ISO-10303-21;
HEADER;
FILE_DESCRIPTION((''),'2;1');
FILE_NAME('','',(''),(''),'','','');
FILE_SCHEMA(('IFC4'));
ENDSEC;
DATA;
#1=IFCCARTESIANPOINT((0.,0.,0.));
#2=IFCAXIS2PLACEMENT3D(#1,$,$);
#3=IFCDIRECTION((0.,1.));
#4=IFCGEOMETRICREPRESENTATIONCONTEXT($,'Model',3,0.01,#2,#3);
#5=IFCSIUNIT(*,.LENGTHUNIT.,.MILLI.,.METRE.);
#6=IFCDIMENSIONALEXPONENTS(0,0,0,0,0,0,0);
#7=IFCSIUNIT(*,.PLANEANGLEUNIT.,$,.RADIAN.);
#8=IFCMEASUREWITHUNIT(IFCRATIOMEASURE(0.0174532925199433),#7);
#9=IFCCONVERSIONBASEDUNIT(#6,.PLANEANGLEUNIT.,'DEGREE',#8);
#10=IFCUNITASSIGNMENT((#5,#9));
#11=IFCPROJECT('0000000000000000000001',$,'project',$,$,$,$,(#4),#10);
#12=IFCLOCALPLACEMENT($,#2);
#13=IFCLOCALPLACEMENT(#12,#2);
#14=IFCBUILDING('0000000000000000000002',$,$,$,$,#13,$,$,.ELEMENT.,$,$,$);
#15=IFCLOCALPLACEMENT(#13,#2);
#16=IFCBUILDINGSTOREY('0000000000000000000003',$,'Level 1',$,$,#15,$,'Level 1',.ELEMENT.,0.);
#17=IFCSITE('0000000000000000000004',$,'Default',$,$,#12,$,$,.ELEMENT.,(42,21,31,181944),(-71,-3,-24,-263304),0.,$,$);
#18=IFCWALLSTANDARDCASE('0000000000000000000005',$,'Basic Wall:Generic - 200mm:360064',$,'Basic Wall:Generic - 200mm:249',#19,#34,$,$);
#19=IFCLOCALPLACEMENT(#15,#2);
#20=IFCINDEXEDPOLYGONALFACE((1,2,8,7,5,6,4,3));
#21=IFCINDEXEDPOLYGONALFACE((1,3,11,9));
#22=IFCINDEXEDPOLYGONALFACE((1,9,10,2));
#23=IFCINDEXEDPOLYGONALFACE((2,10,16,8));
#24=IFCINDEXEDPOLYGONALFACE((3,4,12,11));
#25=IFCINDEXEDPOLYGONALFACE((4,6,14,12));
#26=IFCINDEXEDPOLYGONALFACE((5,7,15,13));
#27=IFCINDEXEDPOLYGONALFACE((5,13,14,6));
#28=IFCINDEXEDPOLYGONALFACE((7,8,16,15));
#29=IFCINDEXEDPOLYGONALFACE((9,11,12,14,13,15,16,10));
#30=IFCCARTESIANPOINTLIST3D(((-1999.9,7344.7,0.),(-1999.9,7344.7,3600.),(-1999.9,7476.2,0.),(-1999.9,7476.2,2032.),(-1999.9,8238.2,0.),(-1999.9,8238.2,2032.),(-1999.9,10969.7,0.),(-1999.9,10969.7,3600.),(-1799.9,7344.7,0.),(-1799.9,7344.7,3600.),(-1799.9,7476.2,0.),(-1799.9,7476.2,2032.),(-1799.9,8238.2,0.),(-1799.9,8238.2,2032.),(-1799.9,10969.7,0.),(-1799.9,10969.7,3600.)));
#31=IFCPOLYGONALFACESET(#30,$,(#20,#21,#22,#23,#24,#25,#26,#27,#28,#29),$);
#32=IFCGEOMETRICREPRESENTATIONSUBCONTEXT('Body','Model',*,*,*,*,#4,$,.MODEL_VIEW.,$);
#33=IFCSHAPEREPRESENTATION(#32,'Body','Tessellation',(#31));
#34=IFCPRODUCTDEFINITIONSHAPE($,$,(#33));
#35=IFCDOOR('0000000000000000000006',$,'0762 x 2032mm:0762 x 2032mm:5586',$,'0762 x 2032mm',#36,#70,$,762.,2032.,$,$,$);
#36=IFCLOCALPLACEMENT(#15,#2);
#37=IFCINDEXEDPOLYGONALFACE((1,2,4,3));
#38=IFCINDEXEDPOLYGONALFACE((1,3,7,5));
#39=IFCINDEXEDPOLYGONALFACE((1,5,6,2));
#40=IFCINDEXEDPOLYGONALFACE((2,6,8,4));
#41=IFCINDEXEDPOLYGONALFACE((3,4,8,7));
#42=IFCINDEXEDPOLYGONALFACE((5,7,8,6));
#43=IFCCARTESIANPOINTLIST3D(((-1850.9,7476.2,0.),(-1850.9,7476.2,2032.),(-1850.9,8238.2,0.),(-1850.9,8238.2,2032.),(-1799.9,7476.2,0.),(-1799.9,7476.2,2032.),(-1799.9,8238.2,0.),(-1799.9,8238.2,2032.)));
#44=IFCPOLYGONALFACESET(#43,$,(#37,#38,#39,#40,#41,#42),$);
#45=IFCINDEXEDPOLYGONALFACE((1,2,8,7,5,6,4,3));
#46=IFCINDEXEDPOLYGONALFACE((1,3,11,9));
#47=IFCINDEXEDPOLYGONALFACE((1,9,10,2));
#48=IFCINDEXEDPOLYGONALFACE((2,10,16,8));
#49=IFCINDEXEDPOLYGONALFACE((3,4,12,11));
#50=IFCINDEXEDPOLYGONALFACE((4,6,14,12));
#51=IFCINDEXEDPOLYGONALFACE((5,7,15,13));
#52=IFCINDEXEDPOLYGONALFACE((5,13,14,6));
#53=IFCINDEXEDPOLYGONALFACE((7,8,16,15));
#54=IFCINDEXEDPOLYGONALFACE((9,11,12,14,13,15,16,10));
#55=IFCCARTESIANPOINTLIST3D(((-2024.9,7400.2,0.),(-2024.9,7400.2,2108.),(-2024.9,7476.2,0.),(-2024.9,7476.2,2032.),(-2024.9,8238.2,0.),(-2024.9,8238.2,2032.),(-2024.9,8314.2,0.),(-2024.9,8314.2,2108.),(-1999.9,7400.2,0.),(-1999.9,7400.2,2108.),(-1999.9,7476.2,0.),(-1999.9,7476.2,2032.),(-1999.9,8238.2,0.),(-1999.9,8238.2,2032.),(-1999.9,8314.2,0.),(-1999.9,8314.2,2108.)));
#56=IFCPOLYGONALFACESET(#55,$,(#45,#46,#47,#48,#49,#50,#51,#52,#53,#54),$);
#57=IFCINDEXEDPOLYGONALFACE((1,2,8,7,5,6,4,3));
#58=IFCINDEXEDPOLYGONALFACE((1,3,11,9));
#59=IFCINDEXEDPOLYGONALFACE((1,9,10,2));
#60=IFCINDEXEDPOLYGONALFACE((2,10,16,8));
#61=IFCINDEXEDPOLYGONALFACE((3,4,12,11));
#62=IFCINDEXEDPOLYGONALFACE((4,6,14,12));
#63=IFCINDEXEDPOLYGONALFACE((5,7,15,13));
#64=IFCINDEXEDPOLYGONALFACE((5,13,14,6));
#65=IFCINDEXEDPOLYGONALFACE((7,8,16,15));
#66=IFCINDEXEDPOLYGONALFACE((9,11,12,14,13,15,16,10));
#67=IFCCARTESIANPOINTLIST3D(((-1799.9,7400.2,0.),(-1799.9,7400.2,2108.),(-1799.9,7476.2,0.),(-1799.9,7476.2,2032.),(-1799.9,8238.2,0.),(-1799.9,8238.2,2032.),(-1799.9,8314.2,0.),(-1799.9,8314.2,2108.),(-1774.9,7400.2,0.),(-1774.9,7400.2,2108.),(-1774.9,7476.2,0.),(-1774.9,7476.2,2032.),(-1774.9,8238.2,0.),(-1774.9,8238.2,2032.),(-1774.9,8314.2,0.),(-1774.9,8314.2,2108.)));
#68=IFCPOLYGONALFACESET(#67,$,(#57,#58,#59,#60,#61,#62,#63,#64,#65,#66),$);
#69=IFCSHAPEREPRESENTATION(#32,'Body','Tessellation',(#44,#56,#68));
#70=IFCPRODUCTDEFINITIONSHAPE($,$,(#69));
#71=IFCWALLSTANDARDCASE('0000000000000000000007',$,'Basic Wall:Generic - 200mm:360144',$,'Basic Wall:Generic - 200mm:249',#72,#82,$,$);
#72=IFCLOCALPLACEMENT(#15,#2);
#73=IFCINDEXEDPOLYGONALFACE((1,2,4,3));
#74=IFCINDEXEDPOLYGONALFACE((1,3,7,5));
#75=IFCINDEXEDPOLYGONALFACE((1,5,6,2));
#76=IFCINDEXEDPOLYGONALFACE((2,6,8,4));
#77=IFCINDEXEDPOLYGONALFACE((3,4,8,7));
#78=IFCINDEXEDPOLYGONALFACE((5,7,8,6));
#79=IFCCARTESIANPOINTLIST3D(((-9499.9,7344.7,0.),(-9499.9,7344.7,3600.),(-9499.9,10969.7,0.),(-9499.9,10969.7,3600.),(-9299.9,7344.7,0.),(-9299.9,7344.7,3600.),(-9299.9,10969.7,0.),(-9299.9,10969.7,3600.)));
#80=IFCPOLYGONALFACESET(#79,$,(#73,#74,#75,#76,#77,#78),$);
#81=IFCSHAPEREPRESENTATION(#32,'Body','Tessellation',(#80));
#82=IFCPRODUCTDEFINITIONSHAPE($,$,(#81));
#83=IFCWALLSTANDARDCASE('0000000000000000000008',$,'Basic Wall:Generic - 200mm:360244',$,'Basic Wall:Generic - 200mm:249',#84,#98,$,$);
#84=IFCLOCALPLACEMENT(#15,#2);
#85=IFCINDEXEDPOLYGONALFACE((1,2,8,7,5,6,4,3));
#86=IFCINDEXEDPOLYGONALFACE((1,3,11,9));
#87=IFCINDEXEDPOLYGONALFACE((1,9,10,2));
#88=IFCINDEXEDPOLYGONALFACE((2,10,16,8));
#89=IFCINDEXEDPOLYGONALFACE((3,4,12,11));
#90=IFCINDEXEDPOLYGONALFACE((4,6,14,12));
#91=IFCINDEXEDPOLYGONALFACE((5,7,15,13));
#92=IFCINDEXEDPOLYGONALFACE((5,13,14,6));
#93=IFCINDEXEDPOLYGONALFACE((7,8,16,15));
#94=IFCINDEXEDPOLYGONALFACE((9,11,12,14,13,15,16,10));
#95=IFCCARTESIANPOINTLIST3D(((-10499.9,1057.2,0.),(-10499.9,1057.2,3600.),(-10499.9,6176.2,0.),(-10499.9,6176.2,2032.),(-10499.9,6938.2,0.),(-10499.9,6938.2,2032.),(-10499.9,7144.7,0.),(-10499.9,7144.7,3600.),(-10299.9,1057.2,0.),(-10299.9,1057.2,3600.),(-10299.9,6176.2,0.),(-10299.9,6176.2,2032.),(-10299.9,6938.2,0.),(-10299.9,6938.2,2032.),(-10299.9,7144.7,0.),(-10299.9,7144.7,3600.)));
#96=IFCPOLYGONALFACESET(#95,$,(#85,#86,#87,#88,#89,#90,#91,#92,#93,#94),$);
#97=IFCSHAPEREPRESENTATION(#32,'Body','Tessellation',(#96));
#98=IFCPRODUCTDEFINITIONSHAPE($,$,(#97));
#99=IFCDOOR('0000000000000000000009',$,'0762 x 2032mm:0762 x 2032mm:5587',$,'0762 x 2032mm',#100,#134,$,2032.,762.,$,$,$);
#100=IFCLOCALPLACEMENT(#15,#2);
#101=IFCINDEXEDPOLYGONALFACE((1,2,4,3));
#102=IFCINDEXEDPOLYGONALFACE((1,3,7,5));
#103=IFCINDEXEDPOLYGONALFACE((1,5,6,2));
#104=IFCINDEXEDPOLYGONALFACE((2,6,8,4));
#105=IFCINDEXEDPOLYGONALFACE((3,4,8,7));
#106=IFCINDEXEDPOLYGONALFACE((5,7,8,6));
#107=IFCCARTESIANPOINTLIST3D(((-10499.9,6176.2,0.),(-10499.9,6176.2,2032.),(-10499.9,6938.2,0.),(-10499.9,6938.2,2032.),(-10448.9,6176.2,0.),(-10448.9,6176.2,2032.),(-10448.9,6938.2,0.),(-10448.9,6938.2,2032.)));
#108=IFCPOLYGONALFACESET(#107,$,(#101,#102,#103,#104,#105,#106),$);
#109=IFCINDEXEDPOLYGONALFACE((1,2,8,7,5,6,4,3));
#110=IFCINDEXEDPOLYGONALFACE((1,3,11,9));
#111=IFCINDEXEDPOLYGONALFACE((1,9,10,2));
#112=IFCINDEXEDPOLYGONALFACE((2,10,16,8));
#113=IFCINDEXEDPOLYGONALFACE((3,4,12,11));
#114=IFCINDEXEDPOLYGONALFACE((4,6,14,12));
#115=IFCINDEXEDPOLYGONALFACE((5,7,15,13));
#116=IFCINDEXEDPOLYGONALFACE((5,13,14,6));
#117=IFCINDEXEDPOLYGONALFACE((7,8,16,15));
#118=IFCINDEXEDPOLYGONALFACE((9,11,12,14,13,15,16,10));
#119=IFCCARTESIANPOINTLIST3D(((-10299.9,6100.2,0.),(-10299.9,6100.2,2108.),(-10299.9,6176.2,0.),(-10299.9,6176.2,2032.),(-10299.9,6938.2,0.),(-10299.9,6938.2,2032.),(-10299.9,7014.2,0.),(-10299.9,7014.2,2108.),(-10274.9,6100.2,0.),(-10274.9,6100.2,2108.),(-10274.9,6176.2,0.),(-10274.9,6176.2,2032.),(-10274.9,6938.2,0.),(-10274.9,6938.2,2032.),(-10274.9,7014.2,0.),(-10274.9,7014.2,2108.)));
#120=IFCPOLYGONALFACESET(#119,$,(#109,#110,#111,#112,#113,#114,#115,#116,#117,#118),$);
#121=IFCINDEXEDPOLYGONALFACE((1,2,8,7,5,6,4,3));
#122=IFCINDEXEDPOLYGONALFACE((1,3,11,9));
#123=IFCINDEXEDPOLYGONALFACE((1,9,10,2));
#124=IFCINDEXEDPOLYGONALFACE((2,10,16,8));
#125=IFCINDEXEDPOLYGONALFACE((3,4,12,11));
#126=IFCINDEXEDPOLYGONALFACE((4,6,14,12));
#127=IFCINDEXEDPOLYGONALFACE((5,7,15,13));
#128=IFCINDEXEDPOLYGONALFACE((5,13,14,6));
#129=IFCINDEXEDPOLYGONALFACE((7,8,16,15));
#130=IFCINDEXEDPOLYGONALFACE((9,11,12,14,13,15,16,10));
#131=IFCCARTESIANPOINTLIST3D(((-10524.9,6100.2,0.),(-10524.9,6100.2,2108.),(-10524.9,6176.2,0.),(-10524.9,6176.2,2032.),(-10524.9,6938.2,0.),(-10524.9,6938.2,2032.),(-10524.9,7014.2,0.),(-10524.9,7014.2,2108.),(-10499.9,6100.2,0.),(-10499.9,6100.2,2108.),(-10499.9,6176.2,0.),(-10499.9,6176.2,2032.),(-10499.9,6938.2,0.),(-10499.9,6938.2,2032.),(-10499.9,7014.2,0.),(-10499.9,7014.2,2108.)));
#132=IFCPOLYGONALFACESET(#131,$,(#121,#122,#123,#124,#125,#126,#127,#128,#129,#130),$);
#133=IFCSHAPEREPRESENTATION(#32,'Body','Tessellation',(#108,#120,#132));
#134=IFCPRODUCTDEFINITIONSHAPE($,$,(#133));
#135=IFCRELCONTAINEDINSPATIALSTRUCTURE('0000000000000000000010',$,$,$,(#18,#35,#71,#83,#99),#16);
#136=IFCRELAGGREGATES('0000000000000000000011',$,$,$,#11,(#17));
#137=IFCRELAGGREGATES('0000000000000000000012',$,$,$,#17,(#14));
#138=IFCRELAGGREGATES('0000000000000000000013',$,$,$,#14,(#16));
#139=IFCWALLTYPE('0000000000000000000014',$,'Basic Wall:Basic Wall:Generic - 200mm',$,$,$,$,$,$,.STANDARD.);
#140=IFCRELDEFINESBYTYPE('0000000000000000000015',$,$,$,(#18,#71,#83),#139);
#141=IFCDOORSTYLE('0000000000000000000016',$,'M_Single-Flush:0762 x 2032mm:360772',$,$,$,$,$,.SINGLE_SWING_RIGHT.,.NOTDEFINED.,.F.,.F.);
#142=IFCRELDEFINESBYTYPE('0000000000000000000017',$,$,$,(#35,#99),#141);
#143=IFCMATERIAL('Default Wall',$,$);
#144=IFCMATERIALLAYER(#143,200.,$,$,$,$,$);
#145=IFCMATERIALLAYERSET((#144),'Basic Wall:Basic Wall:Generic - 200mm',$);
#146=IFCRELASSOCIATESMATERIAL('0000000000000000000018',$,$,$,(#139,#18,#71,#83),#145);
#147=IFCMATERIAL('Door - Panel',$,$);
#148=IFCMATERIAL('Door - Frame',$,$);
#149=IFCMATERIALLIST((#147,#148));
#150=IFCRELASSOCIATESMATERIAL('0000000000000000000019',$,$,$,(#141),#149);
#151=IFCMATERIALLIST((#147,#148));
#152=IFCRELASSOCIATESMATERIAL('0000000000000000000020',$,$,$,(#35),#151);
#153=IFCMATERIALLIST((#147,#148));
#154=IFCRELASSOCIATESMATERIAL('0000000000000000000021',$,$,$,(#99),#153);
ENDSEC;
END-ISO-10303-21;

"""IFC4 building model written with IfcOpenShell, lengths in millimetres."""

from ifc_helpers import new_model, entity, si_unit, converted_unit, direction, frame, frame_2d, origin, origin_2d_with_axis, place, context, subcontext, project, spatial, polyline, rectangle, outline, extrude, source, transform, mapped, material, material_list, layer, layer_set, layer_usage, type_object, type_shapes, element, fill, save


model = new_model("IFC4")

# Units and contexts
model_context = context("Model", 3, precision=0.01, world=origin(), true_north=direction((0.0, 1.0)))
body_context = subcontext(model_context, "Body", "Model", "MODEL_VIEW")
ifc_project = project(units=[si_unit("LENGTHUNIT", "METRE", prefix="MILLI"), converted_unit("PLANEANGLEUNIT", "DEGREE", entity("IfcRatioMeasure", 0.0174532925199433), si_unit("PLANEANGLEUNIT", "RADIAN"), dimensions=[0, 0, 0, 0, 0, 0, 0])], contexts=[model_context])

# Site, building, storey
site_placement = place(None, origin())
site = spatial("IfcSite", under=ifc_project, at=site_placement, Name="Default", CompositionType="ELEMENT", RefLatitude=(42, 21, 31, 181944), RefLongitude=(-71, -3, -24, -263304), RefElevation=0.0)
building_placement = place(site_placement, origin())
building = spatial("IfcBuilding", under=site, at=building_placement, CompositionType="ELEMENT")
storey_placement = place(building_placement, origin())
storey = spatial("IfcBuildingStorey", under=building, at=storey_placement, Name="Level 1", LongName="Level 1", CompositionType="ELEMENT", Elevation=0.0)

# Shared definitions
ifc_material_1 = material(Name="Default Wall")
ifc_material_2 = material(Name="Door - Panel")
ifc_material_3 = material(Name="Door - Frame")

# Shared definitions
ifc_layer_1 = layer(ifc_material_1, 200.0)
ifc_layer_set_1 = layer_set([ifc_layer_1], Name="Basic Wall:Basic Wall:Generic - 200mm")
wall_type_1 = type_object("IfcWallType", Name="Basic Wall:Basic Wall:Generic - 200mm", PredefinedType="STANDARD", material=ifc_layer_set_1)

# Shared definitions
ifc_material_list_1 = material_list([ifc_material_2, ifc_material_3])
door_style_1 = type_object("IfcDoorStyle", Name="M_Single-Flush:0762 x 2032mm:360772", ConstructionType="NOTDEFINED", OperationType="SINGLE_SWING_RIGHT", ParameterTakesPrecedence=False, Sizeable=False, material=ifc_material_list_1)
shared_shape_1 = source(origin(), body_context, "Body", "SweptSolid", [
    extrude(rectangle(XDim=762.0, YDim=51.0, at=frame_2d((0.0, 0.0), x_axis=(1.0, 0.0))), frame((381.0, -27.5, 0.0), z_axis=(0.0, 0.0, 1.0), x_axis=(-1.0, 0.0, 0.0)), (0.0, 0.0, 1.0), 2032.0),
    extrude(outline(polyline([(-457.0, -1035.0), (-381.0, -1035.0), (-381.0, 997.0), (381.0, 997.0), (381.0, -1035.0), (457.0, -1035.0), (457.0, 1073.0), (-457.0, 1073.0), (-457.0, -1035.0)])), frame((381.0, -227.0, 1035.0), z_axis=(0.0, 1.0, 0.0), x_axis=(-1.0, 0.0, 0.0)), (0.0, 0.0, 1.0), 25.0),
    extrude(outline(polyline([(-1073.0, -457.0), (1035.0, -457.0), (1035.0, -381.0), (-997.0, -381.0), (-997.0, 381.0), (1035.0, 381.0), (1035.0, 457.0), (-1073.0, 457.0), (-1073.0, -457.0)])), frame((381.0, -2.0, 1035.0), z_axis=(0.0, 1.0, 0.0), x_axis=(0.0, 0.0, -1.0)), (0.0, 0.0, 1.0), 25.0),
])
type_shapes(door_style_1, [shared_shape_1])

# Wall, opening, door
ifc_layer_usage_1 = layer_usage(ifc_layer_set_1, "AXIS2", "NEGATIVE", 100.0)
wall_1_placement = place(storey_placement, frame((-1899.9, 10969.7, 0.0), z_axis=(0.0, 0.0, 1.0), x_axis=(0.0, -1.0, 0.0)))
wall_1 = element("IfcWallStandardCase", 1, at=wall_1_placement, inside=storey, type_object=wall_type_1, material=ifc_layer_usage_1, Name="Basic Wall:Generic - 200mm:360064", ObjectType="Basic Wall:Generic - 200mm:249", context=body_context, shape_type="SweptSolid", body=[
    extrude(rectangle(XDim=3625.0, YDim=200.0, at=frame_2d((1812.5, 0.0), x_axis=(-1.0, 0.0))), origin(), (0.0, 0.0, 1.0), 3600.0),
])
opening_1_placement = place(wall_1_placement, frame((10969.7, 1899.9, 0.0), z_axis=(0.0, 0.0, 1.0), x_axis=(0.0, 1.0, 0.0)))
opening_1 = element("IfcOpeningElement", 2, at=opening_1_placement, cuts=wall_1, ObjectType="Opening", context=body_context, shape_type="SweptSolid", body=[
    extrude(rectangle(XDim=2032.0, YDim=762.0, at=origin_2d_with_axis()), frame((-2001.9, 7857.2, 1016.0), z_axis=(1.0, 0.0, 0.0), x_axis=(0.0, 0.0, -1.0)), (0.0, 0.0, 1.0), 204.0),
])
ifc_material_list_2 = material_list([ifc_material_2, ifc_material_3])
door_1_placement = place(opening_1_placement, frame((-1797.9, 8238.2, 0.0), z_axis=(0.0, 0.0, 1.0), x_axis=(0.0, -1.0, 0.0)))
door_1 = element("IfcDoor", 3, at=door_1_placement, inside=storey, type_object=door_style_1, material=ifc_material_list_2, Name="0762 x 2032mm:0762 x 2032mm:5586", ObjectType="0762 x 2032mm", OverallHeight=762.0, OverallWidth=2032.0, context=body_context, shape_type="MappedRepresentation", body=[
    mapped(shared_shape_1, transform((0.0, 0.0, 0.0), scale=1.0)),
])
fill(opening_1, door_1)

# Wall
ifc_layer_usage_2 = layer_usage(ifc_layer_set_1, "AXIS2", "NEGATIVE", 100.0)
wall_2_placement = place(storey_placement, frame((-9399.9, 7344.7, 0.0), z_axis=(0.0, 0.0, 1.0), x_axis=(0.0, 1.0, 0.0)))
element("IfcWallStandardCase", 4, at=wall_2_placement, inside=storey, type_object=wall_type_1, material=ifc_layer_usage_2, Name="Basic Wall:Generic - 200mm:360144", ObjectType="Basic Wall:Generic - 200mm:249", context=body_context, shape_type="SweptSolid", body=[
    extrude(rectangle(XDim=3625.0, YDim=200.0, at=frame_2d((1812.5, 0.0), x_axis=(-1.0, 0.0))), origin(), (0.0, 0.0, 1.0), 3600.0),
])

# Wall, opening, door
ifc_layer_usage_3 = layer_usage(ifc_layer_set_1, "AXIS2", "NEGATIVE", 100.0)
wall_3_placement = place(storey_placement, frame((-10399.9, 7144.7, 0.0), z_axis=(0.0, 0.0, 1.0), x_axis=(0.0, -1.0, 0.0)))
wall_3 = element("IfcWallStandardCase", 5, at=wall_3_placement, inside=storey, type_object=wall_type_1, material=ifc_layer_usage_3, Name="Basic Wall:Generic - 200mm:360244", ObjectType="Basic Wall:Generic - 200mm:249", context=body_context, shape_type="SweptSolid", body=[
    extrude(rectangle(XDim=6087.5, YDim=200.0, at=frame_2d((3043.8, 0.0), x_axis=(-1.0, 0.0))), origin(), (0.0, 0.0, 1.0), 3600.0),
])
opening_2_placement = place(wall_3_placement, frame((7144.7, 10399.9, 0.0), z_axis=(0.0, 0.0, 1.0), x_axis=(0.0, 1.0, 0.0)))
opening_2 = element("IfcOpeningElement", 6, at=opening_2_placement, cuts=wall_3, ObjectType="Opening", context=body_context, shape_type="SweptSolid", body=[
    extrude(rectangle(XDim=2032.0, YDim=762.0, at=frame_2d((0.0, 0.0), x_axis=(0.0, 1.0))), frame((-10501.9, 6557.2, 1016.0), z_axis=(1.0, 0.0, 0.0), x_axis=(0.0, -1.0, 0.0)), (0.0, 0.0, 1.0), 204.0),
])
ifc_material_list_3 = material_list([ifc_material_2, ifc_material_3])
door_2_placement = place(opening_2_placement, frame((-10501.9, 6176.2, 0.0), z_axis=(0.0, 0.0, 1.0), x_axis=(0.0, 1.0, 0.0)))
door_2 = element("IfcDoor", 7, at=door_2_placement, inside=storey, type_object=door_style_1, material=ifc_material_list_3, Name="0762 x 2032mm:0762 x 2032mm:5587", ObjectType="0762 x 2032mm", OverallHeight=2032.0, OverallWidth=762.0, context=body_context, shape_type="MappedRepresentation", body=[
    mapped(shared_shape_1, transform((0.0, 0.0, 0.0), scale=1.0)),
])
fill(opening_2, door_2)

save(model, "model.ifc")
